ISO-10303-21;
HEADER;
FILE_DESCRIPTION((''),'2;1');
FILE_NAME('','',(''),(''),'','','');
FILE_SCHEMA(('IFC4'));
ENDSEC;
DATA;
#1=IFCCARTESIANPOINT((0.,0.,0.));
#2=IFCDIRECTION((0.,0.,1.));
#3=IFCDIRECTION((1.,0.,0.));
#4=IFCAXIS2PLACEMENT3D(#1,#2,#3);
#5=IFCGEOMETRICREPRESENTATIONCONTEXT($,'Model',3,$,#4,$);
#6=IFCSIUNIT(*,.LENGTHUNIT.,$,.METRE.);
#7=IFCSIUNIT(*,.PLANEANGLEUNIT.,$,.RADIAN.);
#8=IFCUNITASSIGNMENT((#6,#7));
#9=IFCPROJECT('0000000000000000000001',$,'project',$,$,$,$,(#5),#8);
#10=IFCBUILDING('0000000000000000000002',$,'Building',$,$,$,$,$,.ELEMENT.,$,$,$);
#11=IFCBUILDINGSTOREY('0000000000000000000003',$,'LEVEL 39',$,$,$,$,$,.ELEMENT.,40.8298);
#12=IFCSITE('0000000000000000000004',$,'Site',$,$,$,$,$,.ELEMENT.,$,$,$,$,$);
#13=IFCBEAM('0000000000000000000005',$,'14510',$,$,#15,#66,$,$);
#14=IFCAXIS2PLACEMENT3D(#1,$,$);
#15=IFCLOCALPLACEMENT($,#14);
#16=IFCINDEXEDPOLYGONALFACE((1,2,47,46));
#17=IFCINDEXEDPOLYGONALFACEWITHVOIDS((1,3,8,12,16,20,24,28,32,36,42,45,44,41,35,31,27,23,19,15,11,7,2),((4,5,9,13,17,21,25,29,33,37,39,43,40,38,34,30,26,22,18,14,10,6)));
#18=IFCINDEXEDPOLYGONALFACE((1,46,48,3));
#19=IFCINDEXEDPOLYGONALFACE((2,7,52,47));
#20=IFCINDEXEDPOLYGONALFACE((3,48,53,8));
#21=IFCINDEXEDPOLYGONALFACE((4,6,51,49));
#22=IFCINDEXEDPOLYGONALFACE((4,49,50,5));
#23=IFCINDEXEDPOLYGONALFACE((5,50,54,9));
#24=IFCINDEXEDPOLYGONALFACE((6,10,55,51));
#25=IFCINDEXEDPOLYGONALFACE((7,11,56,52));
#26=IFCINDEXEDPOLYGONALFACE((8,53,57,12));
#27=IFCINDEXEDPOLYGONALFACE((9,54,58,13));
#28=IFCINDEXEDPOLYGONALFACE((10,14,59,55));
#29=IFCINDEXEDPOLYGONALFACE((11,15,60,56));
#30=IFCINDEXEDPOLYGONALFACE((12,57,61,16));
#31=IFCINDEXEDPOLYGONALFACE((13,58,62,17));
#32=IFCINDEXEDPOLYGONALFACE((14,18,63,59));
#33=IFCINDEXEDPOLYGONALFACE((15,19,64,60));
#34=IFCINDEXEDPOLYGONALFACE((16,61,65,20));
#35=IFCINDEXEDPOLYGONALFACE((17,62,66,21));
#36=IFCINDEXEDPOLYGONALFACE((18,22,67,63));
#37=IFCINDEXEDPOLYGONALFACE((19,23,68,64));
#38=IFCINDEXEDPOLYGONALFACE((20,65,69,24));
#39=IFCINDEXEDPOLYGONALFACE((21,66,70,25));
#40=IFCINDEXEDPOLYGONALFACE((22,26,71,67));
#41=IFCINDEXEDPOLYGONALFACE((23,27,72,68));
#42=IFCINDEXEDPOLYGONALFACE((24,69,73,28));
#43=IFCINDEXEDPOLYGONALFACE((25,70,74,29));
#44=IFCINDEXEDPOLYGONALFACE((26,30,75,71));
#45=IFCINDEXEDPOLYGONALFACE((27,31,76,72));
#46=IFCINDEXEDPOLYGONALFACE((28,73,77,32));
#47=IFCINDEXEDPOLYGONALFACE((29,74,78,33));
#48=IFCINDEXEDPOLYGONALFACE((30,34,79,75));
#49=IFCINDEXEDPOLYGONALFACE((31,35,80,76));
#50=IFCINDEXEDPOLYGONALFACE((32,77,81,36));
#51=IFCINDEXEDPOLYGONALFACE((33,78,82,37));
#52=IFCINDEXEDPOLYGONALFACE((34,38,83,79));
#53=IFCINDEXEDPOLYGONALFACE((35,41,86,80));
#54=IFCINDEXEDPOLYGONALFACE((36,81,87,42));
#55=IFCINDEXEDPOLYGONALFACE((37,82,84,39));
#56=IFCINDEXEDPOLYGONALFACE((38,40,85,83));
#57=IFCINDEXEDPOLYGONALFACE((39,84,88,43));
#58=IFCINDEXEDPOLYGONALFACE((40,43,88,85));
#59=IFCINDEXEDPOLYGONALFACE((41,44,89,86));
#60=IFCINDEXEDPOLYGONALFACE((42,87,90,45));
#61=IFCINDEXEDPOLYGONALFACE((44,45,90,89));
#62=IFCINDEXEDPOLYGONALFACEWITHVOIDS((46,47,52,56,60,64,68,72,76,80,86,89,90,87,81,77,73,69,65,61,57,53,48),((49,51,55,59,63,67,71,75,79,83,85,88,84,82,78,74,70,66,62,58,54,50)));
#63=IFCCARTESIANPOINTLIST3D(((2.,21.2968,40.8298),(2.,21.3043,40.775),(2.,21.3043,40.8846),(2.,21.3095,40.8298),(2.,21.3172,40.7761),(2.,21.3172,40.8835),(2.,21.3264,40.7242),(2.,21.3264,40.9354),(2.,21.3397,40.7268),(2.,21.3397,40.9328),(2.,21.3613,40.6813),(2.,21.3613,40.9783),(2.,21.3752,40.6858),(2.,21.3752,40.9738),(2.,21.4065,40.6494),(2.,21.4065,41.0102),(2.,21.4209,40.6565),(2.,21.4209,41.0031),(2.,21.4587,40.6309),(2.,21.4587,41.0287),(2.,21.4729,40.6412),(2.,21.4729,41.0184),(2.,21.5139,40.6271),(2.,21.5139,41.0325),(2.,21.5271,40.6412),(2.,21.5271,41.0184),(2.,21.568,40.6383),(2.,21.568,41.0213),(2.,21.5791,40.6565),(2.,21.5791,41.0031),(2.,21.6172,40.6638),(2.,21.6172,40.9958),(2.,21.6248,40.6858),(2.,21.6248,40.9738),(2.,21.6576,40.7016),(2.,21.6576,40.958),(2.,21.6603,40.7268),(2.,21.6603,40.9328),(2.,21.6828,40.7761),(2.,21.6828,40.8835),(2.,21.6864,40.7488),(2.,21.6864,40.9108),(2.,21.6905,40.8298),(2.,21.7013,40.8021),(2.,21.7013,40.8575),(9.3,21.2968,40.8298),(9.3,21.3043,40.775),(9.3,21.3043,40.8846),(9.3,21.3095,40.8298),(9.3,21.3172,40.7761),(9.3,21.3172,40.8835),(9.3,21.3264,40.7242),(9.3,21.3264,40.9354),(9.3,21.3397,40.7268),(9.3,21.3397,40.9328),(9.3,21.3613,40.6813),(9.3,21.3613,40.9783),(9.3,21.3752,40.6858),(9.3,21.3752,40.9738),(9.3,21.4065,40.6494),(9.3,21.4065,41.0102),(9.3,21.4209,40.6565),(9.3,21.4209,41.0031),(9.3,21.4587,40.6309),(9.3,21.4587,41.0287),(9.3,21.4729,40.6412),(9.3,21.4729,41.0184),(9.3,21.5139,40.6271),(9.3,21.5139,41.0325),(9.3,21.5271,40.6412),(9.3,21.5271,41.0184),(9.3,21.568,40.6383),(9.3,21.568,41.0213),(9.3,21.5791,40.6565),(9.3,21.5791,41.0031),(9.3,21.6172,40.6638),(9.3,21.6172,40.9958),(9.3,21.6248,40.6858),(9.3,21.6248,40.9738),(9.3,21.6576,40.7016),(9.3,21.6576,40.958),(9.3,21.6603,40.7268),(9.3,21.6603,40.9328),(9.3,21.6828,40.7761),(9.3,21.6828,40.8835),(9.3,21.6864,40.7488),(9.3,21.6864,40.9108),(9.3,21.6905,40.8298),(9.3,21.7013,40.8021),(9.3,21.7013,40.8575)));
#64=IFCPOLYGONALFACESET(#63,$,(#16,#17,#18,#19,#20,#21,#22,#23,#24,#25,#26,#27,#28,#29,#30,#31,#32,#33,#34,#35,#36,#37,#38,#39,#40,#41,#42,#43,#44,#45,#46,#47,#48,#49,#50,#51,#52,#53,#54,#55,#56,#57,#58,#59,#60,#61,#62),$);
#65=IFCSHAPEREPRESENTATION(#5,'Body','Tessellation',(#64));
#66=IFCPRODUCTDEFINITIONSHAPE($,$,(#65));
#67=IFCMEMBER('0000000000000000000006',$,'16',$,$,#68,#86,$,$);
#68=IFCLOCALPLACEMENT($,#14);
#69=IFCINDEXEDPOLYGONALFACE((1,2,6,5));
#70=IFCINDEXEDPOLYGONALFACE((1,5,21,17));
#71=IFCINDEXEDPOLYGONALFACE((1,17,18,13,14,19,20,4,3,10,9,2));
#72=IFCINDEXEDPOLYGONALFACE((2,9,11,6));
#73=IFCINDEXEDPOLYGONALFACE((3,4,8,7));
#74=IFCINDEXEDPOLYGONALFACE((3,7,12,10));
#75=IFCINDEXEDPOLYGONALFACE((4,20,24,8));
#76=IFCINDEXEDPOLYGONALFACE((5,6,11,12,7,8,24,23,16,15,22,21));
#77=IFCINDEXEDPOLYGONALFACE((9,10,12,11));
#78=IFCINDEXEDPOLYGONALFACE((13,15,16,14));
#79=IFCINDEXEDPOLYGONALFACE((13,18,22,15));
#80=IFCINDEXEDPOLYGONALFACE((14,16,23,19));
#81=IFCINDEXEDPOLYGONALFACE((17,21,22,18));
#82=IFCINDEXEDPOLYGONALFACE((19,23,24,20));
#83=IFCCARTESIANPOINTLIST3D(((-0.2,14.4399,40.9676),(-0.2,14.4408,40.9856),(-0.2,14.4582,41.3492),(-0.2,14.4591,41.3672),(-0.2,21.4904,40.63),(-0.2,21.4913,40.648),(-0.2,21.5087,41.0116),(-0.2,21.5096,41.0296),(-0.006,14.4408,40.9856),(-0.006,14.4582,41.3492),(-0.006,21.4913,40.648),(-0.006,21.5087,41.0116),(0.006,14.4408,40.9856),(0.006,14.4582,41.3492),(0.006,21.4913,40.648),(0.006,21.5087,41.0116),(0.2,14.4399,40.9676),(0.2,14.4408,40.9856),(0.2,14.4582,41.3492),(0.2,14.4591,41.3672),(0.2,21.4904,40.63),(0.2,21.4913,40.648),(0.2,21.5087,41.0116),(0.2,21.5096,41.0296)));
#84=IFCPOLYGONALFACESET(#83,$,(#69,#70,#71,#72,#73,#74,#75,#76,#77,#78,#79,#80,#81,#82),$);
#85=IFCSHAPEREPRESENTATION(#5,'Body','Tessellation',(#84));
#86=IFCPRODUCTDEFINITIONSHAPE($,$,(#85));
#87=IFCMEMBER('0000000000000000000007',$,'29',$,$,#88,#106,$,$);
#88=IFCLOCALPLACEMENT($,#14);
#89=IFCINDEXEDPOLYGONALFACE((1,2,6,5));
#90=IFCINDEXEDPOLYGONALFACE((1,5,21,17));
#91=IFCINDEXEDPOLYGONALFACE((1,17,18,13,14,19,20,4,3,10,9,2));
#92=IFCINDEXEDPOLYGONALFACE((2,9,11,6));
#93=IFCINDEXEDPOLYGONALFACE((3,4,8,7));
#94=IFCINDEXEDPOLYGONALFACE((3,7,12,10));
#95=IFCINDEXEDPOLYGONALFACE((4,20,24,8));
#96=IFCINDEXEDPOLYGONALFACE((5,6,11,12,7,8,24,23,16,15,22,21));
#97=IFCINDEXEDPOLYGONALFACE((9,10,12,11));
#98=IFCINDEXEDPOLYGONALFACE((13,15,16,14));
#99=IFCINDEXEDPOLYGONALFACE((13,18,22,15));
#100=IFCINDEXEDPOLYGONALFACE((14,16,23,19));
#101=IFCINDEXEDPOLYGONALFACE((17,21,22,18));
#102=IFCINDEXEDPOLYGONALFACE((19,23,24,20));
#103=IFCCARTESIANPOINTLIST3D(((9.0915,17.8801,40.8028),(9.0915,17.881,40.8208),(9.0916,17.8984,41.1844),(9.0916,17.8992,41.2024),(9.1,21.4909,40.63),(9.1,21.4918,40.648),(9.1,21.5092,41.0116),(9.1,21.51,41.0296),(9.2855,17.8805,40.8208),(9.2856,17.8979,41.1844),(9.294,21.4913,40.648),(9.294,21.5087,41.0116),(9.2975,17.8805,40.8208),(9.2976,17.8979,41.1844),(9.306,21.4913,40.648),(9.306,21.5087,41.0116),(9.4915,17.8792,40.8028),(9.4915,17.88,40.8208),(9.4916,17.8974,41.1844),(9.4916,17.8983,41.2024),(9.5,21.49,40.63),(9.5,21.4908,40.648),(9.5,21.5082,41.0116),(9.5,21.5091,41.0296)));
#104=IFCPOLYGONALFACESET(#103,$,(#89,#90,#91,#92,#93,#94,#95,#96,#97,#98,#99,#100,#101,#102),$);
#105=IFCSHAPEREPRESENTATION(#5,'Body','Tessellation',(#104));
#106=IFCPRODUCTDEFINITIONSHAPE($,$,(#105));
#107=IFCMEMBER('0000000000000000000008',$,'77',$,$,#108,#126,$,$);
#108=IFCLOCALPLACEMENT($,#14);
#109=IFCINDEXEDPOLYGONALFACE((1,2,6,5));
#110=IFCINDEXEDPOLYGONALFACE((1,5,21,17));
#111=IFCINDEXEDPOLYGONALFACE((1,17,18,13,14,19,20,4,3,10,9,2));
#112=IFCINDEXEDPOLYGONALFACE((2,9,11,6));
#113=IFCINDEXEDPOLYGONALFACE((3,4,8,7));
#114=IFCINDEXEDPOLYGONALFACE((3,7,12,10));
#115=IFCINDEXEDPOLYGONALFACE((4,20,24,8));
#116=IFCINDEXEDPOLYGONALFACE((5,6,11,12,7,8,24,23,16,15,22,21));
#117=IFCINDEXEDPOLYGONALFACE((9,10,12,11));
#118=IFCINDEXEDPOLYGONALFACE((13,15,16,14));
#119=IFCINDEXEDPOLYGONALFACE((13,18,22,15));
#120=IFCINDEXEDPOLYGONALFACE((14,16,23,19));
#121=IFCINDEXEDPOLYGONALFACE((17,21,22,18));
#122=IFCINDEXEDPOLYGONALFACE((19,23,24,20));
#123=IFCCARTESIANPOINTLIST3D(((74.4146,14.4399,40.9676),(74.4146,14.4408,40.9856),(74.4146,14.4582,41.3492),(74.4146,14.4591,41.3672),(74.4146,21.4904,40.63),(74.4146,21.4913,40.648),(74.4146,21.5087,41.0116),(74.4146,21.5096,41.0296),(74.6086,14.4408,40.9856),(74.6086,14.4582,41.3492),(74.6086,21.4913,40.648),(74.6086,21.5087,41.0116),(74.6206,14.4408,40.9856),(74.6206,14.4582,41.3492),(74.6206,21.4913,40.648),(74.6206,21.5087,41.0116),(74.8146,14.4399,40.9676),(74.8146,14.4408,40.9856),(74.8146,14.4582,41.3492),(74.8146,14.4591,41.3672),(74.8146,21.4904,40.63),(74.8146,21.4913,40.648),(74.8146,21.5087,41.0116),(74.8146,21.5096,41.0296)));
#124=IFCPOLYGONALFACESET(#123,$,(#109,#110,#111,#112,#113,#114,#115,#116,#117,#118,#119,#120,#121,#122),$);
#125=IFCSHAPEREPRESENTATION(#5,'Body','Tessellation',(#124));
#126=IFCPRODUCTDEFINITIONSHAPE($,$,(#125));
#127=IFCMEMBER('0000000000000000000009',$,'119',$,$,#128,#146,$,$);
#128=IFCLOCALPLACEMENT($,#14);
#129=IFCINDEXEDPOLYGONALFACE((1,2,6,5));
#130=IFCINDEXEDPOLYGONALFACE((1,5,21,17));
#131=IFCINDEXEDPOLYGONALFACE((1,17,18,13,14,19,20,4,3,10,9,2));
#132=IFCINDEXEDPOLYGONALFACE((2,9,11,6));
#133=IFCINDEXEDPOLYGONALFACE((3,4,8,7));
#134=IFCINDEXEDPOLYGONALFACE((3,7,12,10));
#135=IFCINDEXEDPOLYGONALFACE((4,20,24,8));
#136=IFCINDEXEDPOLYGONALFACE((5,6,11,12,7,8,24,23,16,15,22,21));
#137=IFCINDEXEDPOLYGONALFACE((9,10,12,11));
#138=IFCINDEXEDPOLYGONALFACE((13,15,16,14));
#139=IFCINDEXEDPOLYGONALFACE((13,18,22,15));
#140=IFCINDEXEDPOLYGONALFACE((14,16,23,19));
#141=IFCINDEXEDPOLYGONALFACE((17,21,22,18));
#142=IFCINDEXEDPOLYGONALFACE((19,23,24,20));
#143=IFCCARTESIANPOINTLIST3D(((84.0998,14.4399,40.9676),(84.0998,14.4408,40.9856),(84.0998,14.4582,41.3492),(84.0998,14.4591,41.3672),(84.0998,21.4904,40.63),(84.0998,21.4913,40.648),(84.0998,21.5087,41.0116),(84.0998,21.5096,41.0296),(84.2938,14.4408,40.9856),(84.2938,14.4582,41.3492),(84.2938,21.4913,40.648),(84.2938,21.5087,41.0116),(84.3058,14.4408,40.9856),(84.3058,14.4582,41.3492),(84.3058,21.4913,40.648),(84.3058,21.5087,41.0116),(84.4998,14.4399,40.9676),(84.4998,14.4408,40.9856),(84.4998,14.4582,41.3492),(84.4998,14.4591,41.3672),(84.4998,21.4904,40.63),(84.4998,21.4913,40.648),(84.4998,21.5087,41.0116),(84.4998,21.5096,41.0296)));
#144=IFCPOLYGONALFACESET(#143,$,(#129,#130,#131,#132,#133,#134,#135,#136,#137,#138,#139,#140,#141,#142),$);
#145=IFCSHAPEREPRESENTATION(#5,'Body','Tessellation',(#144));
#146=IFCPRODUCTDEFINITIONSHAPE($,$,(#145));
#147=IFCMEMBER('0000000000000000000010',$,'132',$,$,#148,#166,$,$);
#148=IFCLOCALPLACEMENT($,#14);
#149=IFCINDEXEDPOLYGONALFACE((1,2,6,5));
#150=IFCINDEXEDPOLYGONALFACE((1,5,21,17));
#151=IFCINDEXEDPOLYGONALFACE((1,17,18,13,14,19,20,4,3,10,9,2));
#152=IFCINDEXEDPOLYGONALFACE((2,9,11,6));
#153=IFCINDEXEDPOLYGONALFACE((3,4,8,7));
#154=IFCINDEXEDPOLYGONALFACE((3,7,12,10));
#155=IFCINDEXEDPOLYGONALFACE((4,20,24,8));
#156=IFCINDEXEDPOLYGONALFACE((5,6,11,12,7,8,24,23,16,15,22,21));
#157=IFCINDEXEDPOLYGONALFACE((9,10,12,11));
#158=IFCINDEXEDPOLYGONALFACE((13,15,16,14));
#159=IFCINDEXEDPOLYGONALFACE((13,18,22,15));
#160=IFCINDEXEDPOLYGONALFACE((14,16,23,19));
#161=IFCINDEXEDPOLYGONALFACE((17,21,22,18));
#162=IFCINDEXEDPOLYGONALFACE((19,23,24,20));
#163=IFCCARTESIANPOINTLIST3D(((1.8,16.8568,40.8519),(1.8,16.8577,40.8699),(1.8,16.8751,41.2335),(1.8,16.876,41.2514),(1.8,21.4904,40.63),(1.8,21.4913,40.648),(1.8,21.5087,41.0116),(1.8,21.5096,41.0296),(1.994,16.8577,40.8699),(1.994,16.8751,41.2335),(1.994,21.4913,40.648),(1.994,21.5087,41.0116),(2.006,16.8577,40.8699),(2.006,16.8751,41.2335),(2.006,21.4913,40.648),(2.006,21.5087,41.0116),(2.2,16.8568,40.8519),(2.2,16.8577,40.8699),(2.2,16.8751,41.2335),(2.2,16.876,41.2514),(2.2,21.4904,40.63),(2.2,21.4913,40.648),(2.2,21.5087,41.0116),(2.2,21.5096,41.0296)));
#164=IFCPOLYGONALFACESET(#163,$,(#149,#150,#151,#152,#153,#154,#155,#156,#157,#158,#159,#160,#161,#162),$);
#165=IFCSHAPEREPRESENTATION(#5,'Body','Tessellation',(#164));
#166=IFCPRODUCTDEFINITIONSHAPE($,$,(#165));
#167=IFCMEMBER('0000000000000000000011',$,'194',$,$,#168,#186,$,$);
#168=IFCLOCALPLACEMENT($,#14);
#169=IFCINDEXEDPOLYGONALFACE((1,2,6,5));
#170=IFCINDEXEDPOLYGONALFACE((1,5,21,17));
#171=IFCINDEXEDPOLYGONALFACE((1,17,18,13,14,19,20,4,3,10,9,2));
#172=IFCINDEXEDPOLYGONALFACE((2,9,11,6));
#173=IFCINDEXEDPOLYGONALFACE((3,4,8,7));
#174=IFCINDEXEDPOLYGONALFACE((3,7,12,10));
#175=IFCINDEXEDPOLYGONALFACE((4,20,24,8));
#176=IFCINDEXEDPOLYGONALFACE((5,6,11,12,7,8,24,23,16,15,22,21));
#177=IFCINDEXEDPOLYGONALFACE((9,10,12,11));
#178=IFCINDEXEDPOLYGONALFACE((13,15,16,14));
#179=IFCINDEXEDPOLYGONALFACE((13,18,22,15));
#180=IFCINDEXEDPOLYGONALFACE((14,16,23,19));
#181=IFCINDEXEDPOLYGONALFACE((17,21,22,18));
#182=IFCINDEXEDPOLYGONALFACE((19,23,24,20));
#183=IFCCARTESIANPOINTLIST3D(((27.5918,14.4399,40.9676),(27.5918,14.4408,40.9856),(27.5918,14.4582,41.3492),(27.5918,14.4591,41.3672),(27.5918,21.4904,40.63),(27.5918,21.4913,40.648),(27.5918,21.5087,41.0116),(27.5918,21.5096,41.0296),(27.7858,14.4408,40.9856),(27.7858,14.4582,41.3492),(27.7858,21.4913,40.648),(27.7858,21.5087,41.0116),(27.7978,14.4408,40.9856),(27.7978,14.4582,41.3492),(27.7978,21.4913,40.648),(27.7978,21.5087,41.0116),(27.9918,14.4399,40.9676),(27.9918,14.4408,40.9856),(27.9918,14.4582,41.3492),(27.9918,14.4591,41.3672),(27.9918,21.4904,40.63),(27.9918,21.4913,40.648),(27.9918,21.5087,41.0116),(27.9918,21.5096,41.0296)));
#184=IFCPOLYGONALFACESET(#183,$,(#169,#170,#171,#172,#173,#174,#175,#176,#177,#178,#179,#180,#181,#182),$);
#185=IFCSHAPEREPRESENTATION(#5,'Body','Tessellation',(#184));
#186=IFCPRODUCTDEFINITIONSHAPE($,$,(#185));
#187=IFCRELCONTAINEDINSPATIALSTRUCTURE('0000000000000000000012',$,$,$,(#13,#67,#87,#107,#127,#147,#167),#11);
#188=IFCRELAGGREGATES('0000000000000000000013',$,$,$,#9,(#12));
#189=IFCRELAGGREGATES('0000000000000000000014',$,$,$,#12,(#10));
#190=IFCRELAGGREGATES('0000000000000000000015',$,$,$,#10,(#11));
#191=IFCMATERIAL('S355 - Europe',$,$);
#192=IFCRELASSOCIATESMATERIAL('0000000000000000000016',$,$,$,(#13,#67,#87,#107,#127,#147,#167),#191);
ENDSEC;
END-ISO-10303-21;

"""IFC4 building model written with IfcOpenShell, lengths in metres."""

from ifc_helpers import new_model, si_unit, frame, origin_with_axes, origin_2d_with_axis, place, context, project, spatial, hollow_circle, i_section, extrude, material, material_profile, profile_set, profile_usage, element, save


model = new_model("IFC4")

# Units and contexts
model_context = context("Model", 3, world=origin_with_axes())
ifc_project = project(units=[si_unit("LENGTHUNIT", "METRE"), si_unit("PLANEANGLEUNIT", "RADIAN")], contexts=[model_context])

# Site, building, storey
site = spatial("IfcSite", under=ifc_project, Name="Site", CompositionType="ELEMENT")
building = spatial("IfcBuilding", under=site, Name="Building", CompositionType="ELEMENT")
storey = spatial("IfcBuildingStorey", under=building, Name="LEVEL 39", CompositionType="ELEMENT", Elevation=40.8298)

# Beam
ifc_material = material(Name="S355 - Europe")
ifc_material_profile_1 = material_profile(ifc_material, hollow_circle(Radius=0.2032, WallThickness=0.0127, at=origin_2d_with_axis()))
ifc_profile_set_1 = profile_set([ifc_material_profile_1])
ifc_profile_usage_1 = profile_usage(ifc_profile_set_1, cardinal=10)
beam_1_placement = place(None, frame((9.3, 21.5, 40.8298), z_axis=(-1.0, 0.0, 0.0), x_axis=(0.0, -1.0, 0.0)))
element("IfcBeam", 1, at=beam_1_placement, inside=storey, material=ifc_profile_usage_1, Name="14510", context=model_context, shape_type="SweptSolid", body=[
    extrude(hollow_circle(Radius=0.2032, WallThickness=0.0127, at=origin_2d_with_axis()), origin_with_axes(), (0.0, 0.0, 1.0), 7.3),
])

# Members
ifc_material_profile_2 = material_profile(ifc_material, i_section(OverallWidth=0.4, OverallDepth=0.4, WebThickness=0.012, FlangeThickness=0.018, at=origin_2d_with_axis()))
ifc_profile_set_2 = profile_set([ifc_material_profile_2])
ifc_profile_usage_2 = profile_usage(ifc_profile_set_2, cardinal=10)
member_1_placement = place(None, frame((0.0, 21.5, 40.8298), z_axis=(0.0, -0.998856, 0.047828), x_axis=(1.0, 0.0, 0.0)))
element("IfcMember", 2, at=member_1_placement, inside=storey, material=ifc_profile_usage_2, Name="16", context=model_context, shape_type="SweptSolid", body=[
    extrude(i_section(OverallWidth=0.4, OverallDepth=0.4, WebThickness=0.012, FlangeThickness=0.018, at=origin_2d_with_axis()), origin_with_axes(), (0.0, 0.0, 1.0), 7.0586),
])
ifc_material_profile_3 = material_profile(ifc_material, i_section(OverallWidth=0.4, OverallDepth=0.4, WebThickness=0.012, FlangeThickness=0.018, at=origin_2d_with_axis()))
ifc_profile_set_3 = profile_set([ifc_material_profile_3])
ifc_profile_usage_3 = profile_usage(ifc_profile_set_3, cardinal=10)
member_2_placement = place(None, frame((9.3, 21.5, 40.8298), z_axis=(-0.002335, -0.998854, 0.047802), x_axis=(0.999997, -0.002337, 0.0)))
element("IfcMember", 3, at=member_2_placement, inside=storey, material=ifc_profile_usage_3, Name="29", context=model_context, shape_type="SweptSolid", body=[
    extrude(i_section(OverallWidth=0.4, OverallDepth=0.4, WebThickness=0.012, FlangeThickness=0.018, at=origin_2d_with_axis()), origin_with_axes(), (0.0, 0.0, 1.0), 3.6149),
])
ifc_material_profile_4 = material_profile(ifc_material, i_section(OverallWidth=0.4, OverallDepth=0.4, WebThickness=0.012, FlangeThickness=0.018, at=origin_2d_with_axis()))
ifc_profile_set_4 = profile_set([ifc_material_profile_4])
ifc_profile_usage_4 = profile_usage(ifc_profile_set_4, cardinal=10)
member_3_placement = place(None, frame((74.6146, 21.5, 40.8298), z_axis=(0.0, -0.998856, 0.047828), x_axis=(1.0, 0.0, 0.0)))
element("IfcMember", 4, at=member_3_placement, inside=storey, material=ifc_profile_usage_4, Name="77", context=model_context, shape_type="SweptSolid", body=[
    extrude(i_section(OverallWidth=0.4, OverallDepth=0.4, WebThickness=0.012, FlangeThickness=0.018, at=origin_2d_with_axis()), origin_with_axes(), (0.0, 0.0, 1.0), 7.0586),
])
ifc_material_profile_5 = material_profile(ifc_material, i_section(OverallWidth=0.4, OverallDepth=0.4, WebThickness=0.012, FlangeThickness=0.018, at=origin_2d_with_axis()))
ifc_profile_set_5 = profile_set([ifc_material_profile_5])
ifc_profile_usage_5 = profile_usage(ifc_profile_set_5, cardinal=10)
member_4_placement = place(None, frame((84.2998, 21.5, 40.8298), z_axis=(0.0, -0.998856, 0.047828), x_axis=(1.0, 0.0, 0.0)))
element("IfcMember", 5, at=member_4_placement, inside=storey, material=ifc_profile_usage_5, Name="119", context=model_context, shape_type="SweptSolid", body=[
    extrude(i_section(OverallWidth=0.4, OverallDepth=0.4, WebThickness=0.012, FlangeThickness=0.018, at=origin_2d_with_axis()), origin_with_axes(), (0.0, 0.0, 1.0), 7.0586),
])
ifc_material_profile_6 = material_profile(ifc_material, i_section(OverallWidth=0.4, OverallDepth=0.4, WebThickness=0.012, FlangeThickness=0.018, at=origin_2d_with_axis()))
ifc_profile_set_6 = profile_set([ifc_material_profile_6])
ifc_profile_usage_6 = profile_usage(ifc_profile_set_6, cardinal=10)
member_5_placement = place(None, frame((2.0, 21.5, 40.8298), z_axis=(0.0, -0.998856, 0.047828), x_axis=(1.0, 0.0, 0.0)))
element("IfcMember", 6, at=member_5_placement, inside=storey, material=ifc_profile_usage_6, Name="132", context=model_context, shape_type="SweptSolid", body=[
    extrude(i_section(OverallWidth=0.4, OverallDepth=0.4, WebThickness=0.012, FlangeThickness=0.018, at=origin_2d_with_axis()), origin_with_axes(), (0.0, 0.0, 1.0), 4.6389),
])
ifc_material_profile_7 = material_profile(ifc_material, i_section(OverallWidth=0.4, OverallDepth=0.4, WebThickness=0.012, FlangeThickness=0.018, at=origin_2d_with_axis()))
ifc_profile_set_7 = profile_set([ifc_material_profile_7])
ifc_profile_usage_7 = profile_usage(ifc_profile_set_7, cardinal=10)
member_6_placement = place(None, frame((27.7918, 21.5, 40.8298), z_axis=(0.0, -0.998856, 0.047828), x_axis=(1.0, 0.0, 0.0)))
element("IfcMember", 7, at=member_6_placement, inside=storey, material=ifc_profile_usage_7, Name="194", context=model_context, shape_type="SweptSolid", body=[
    extrude(i_section(OverallWidth=0.4, OverallDepth=0.4, WebThickness=0.012, FlangeThickness=0.018, at=origin_2d_with_axis()), origin_with_axes(), (0.0, 0.0, 1.0), 7.0586),
])

save(model, "model.ifc")
